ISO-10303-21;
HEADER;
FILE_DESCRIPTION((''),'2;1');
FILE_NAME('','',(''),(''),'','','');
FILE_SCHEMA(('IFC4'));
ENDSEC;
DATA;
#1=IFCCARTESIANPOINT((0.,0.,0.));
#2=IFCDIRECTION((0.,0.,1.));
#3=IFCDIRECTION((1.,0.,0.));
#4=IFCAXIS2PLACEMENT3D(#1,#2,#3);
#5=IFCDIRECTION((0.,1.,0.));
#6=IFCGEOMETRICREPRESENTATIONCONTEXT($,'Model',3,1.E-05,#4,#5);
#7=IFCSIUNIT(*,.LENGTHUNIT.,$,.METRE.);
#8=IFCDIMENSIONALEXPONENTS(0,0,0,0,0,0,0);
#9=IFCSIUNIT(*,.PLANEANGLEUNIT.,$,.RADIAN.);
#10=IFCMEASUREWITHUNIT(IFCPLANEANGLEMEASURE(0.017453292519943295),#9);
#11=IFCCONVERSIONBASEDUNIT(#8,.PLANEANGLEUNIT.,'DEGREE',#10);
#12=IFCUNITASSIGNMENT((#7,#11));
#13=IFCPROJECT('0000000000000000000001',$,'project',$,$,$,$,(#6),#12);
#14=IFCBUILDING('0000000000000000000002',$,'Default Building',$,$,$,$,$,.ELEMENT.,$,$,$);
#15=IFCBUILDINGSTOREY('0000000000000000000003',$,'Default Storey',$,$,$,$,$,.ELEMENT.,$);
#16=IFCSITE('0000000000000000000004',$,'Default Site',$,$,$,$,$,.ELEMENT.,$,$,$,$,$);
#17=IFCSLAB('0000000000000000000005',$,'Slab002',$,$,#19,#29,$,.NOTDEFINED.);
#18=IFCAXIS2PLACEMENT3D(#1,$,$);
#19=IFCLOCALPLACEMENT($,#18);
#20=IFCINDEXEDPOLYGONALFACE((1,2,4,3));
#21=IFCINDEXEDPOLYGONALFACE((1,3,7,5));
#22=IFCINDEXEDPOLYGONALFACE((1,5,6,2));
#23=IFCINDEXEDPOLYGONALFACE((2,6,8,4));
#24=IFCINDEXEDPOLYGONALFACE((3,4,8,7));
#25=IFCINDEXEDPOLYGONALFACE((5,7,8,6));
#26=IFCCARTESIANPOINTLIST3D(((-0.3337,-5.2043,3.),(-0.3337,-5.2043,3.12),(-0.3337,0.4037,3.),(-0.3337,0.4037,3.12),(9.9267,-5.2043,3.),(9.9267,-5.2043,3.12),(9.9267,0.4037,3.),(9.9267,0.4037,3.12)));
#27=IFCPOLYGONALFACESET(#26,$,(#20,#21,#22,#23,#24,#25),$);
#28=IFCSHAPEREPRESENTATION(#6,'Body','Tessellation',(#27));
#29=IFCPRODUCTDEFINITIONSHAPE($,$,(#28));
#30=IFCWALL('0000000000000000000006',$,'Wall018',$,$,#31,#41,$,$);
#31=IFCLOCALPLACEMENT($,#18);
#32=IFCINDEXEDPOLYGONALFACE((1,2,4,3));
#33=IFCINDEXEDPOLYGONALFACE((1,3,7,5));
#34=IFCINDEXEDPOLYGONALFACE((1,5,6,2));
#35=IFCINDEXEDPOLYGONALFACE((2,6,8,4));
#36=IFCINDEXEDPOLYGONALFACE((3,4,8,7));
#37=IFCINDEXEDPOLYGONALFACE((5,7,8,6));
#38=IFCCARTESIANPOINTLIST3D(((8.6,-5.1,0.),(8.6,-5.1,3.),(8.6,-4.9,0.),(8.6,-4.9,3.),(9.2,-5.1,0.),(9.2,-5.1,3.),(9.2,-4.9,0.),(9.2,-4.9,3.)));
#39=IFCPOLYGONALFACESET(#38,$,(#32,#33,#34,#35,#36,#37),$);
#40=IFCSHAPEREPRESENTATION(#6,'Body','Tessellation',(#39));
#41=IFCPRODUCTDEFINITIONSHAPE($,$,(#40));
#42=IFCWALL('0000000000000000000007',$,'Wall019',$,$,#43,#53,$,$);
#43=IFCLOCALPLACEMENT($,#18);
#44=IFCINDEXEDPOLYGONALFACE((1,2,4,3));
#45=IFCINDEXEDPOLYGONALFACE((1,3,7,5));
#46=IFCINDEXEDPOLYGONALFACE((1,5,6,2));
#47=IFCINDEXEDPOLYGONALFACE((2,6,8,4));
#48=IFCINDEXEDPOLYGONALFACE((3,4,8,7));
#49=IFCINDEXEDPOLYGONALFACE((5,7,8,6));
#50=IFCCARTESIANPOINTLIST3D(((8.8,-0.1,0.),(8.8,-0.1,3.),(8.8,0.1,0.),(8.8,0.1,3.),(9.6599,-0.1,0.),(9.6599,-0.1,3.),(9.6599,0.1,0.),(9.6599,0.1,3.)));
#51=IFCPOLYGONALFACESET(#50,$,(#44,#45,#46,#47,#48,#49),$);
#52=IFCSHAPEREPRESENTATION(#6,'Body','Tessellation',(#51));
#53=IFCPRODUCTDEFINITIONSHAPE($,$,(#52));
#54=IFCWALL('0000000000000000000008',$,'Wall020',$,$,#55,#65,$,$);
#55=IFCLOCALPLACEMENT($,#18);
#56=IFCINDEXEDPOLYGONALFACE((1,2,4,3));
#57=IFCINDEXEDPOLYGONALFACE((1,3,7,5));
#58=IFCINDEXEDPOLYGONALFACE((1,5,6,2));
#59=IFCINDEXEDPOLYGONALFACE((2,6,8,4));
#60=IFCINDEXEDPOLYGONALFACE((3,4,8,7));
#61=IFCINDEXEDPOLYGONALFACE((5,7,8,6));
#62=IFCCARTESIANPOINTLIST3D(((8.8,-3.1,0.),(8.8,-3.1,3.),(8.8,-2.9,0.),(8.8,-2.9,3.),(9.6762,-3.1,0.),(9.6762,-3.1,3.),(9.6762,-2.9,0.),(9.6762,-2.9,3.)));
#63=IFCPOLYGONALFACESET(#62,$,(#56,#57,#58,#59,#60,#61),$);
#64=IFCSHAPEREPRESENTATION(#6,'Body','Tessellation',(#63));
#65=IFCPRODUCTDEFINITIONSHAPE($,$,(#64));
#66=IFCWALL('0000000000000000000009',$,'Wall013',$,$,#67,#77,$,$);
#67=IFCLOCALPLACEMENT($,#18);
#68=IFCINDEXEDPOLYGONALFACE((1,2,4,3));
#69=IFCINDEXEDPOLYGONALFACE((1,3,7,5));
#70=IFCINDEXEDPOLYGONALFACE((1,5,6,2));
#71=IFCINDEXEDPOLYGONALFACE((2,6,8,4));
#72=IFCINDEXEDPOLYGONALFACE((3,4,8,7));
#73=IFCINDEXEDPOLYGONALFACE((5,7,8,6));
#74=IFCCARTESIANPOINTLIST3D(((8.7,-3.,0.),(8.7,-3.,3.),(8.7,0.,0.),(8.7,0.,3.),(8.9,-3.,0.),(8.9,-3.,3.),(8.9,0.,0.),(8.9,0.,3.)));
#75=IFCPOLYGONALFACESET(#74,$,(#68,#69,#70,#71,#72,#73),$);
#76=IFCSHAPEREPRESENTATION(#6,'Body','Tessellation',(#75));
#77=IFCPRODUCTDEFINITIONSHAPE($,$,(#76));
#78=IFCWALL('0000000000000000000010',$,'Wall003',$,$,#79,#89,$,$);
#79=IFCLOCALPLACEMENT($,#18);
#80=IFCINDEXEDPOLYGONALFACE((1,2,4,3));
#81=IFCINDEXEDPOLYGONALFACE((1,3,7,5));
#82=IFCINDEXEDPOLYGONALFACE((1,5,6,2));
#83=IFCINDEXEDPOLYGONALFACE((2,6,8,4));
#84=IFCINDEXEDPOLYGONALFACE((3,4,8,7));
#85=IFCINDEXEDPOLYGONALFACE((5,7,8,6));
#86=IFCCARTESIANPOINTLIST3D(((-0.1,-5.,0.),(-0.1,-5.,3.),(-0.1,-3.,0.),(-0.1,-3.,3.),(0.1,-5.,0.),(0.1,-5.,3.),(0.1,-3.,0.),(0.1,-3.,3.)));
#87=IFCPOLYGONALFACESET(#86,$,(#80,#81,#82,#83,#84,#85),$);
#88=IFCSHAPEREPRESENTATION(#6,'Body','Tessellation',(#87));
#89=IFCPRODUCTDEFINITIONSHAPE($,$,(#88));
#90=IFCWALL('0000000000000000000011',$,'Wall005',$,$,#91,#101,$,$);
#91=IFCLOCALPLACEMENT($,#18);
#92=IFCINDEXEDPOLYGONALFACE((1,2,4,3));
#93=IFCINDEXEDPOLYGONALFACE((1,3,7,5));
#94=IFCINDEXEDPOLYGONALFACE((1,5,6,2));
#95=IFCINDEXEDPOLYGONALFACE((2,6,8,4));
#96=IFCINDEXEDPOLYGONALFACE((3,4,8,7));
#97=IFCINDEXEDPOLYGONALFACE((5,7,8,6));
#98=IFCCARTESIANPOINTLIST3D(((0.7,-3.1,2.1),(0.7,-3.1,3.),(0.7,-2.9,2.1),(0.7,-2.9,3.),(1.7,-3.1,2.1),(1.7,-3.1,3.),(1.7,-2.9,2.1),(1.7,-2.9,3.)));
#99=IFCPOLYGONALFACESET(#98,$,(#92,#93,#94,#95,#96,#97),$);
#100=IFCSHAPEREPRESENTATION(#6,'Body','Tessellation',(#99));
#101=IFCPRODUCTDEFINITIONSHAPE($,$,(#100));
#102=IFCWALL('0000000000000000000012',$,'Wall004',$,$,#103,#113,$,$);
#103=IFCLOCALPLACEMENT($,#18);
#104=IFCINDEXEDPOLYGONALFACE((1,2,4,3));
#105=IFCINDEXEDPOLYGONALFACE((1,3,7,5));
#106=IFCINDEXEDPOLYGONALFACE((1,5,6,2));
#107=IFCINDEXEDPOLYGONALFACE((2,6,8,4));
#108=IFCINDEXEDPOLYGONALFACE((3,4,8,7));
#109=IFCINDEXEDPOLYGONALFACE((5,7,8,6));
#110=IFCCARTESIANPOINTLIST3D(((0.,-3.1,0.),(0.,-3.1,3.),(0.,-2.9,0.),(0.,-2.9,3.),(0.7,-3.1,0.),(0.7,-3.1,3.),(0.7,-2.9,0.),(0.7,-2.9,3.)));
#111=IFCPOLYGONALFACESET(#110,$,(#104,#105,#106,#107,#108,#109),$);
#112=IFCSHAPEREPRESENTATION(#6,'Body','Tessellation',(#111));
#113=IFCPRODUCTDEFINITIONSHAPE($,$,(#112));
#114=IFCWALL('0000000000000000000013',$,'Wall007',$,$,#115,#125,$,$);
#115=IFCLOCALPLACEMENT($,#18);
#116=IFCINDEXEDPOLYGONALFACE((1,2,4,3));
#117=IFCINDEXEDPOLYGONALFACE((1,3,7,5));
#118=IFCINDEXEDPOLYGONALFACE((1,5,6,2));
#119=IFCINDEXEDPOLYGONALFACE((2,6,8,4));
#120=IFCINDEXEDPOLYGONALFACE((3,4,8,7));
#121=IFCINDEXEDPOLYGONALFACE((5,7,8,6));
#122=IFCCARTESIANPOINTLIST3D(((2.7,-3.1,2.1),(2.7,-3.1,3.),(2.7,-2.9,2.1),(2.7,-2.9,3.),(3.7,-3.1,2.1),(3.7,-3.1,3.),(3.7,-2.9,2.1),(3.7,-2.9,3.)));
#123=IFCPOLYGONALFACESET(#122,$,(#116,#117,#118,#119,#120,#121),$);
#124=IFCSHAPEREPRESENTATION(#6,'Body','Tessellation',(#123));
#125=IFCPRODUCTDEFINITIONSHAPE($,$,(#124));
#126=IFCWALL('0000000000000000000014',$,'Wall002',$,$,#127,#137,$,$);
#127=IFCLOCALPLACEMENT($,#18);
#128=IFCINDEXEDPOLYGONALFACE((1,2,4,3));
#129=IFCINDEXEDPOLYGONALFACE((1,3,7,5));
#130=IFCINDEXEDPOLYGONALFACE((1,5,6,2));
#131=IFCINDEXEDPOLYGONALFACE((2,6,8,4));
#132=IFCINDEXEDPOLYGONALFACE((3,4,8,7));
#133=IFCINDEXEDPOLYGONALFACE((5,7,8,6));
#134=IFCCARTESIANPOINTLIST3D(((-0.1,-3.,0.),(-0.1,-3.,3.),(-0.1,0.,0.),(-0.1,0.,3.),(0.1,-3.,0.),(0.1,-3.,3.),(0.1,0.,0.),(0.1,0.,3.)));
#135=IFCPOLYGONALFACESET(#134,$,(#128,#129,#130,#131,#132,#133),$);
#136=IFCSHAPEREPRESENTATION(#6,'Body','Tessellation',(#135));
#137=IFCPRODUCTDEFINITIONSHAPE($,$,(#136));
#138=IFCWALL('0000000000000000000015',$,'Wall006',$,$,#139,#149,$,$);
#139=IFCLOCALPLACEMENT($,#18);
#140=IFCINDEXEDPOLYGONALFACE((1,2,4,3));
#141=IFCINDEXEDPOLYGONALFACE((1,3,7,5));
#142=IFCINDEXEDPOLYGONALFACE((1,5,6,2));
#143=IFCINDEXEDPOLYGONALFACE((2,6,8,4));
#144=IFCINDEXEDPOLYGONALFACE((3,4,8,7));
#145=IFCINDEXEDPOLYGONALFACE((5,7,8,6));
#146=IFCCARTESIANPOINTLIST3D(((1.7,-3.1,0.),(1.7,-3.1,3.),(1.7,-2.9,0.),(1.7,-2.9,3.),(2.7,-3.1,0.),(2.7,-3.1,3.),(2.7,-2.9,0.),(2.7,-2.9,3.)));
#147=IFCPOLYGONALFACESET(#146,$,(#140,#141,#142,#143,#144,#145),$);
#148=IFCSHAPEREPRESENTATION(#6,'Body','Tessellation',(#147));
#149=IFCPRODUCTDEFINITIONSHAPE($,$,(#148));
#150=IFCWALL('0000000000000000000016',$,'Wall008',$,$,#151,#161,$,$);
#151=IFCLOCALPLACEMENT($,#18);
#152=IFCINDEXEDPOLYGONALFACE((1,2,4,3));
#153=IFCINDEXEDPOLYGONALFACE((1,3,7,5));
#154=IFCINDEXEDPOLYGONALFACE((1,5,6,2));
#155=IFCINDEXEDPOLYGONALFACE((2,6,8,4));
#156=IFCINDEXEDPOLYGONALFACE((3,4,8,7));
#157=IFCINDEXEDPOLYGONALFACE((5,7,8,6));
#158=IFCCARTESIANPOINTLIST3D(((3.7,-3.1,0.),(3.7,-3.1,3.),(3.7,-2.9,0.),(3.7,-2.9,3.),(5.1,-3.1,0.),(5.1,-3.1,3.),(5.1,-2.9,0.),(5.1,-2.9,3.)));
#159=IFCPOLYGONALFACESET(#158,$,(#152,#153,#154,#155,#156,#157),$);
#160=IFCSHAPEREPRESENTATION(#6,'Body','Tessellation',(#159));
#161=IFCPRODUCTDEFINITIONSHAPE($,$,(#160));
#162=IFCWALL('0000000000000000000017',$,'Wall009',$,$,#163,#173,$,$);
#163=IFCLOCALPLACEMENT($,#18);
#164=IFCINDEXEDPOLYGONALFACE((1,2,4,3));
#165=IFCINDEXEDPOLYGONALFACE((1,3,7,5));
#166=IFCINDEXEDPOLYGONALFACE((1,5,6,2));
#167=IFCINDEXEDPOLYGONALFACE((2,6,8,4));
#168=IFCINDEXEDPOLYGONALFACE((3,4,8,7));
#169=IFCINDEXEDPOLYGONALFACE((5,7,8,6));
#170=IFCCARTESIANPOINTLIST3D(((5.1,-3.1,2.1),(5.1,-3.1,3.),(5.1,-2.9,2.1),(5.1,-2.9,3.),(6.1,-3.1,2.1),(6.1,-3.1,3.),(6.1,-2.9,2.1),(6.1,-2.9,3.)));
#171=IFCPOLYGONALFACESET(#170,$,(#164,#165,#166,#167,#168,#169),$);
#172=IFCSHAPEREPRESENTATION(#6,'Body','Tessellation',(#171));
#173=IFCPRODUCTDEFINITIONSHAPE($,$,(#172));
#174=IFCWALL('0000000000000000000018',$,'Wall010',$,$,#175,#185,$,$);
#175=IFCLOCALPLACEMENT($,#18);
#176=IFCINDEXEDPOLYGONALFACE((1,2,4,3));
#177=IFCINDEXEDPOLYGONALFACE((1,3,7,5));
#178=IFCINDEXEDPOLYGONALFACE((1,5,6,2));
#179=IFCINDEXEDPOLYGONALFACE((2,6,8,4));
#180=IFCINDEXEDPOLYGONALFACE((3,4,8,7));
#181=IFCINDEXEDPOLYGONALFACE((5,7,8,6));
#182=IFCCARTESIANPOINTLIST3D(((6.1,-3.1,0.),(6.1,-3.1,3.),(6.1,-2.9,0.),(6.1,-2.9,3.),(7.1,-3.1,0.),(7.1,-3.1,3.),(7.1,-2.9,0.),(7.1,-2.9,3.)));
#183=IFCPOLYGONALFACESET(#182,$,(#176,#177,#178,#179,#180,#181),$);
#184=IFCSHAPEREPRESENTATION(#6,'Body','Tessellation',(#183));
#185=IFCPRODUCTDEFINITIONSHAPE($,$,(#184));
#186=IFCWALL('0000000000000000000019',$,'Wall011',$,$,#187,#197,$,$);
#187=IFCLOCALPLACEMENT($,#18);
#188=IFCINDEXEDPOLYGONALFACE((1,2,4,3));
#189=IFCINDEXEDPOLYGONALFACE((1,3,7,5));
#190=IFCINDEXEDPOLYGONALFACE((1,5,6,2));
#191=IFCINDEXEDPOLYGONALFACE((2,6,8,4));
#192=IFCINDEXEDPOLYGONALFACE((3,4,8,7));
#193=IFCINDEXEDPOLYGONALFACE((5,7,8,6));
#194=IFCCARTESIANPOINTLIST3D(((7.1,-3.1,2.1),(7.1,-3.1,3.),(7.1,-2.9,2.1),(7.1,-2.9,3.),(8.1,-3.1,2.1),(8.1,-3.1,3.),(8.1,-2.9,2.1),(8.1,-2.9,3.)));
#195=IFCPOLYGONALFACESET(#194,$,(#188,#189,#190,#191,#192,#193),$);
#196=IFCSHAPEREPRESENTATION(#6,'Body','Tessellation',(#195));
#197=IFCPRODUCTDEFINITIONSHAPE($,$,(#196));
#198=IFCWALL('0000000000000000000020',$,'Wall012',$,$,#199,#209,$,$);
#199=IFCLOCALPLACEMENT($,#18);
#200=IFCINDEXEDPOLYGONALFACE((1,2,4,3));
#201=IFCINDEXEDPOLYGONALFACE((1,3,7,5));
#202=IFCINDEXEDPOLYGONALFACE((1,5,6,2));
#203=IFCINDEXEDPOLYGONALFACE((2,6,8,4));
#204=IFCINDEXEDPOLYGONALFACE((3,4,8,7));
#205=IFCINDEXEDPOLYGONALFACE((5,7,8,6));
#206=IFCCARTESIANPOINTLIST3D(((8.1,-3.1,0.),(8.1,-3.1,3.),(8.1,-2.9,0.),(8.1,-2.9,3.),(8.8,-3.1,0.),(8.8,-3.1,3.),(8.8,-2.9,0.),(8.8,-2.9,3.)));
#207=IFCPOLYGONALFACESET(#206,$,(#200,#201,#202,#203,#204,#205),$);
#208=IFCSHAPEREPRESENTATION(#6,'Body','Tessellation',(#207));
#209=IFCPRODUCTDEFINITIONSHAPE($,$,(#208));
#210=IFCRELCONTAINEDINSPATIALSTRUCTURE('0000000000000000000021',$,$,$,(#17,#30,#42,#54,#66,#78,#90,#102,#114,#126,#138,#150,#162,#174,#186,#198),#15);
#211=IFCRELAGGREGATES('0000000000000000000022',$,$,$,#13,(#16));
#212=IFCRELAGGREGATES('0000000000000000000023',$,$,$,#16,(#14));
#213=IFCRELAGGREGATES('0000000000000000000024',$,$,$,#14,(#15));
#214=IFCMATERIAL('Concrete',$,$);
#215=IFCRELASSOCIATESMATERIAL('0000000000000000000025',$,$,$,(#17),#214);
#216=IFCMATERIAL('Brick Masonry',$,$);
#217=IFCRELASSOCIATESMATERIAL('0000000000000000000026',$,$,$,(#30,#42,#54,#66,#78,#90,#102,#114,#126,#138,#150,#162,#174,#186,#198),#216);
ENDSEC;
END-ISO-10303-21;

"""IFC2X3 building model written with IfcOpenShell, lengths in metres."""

from ifc_helpers import new_model, entity, si_unit, converted_unit, direction, frame, frame_2d, origin_with_axes, place, context, project, spatial, rectangle, extrude, material, element, save


model = new_model("IFC2X3")

# Units and contexts
model_context = context("Model", 3, precision=1e-05, world=origin_with_axes(), true_north=direction((0.0, 1.0, 0.0)))
ifc_project = project(units=[si_unit("LENGTHUNIT", "METRE"), converted_unit("PLANEANGLEUNIT", "DEGREE", entity("IfcPlaneAngleMeasure", 0.017453292519943295), si_unit("PLANEANGLEUNIT", "RADIAN"), dimensions=[0, 0, 0, 0, 0, 0, 0])], contexts=[model_context])

# Site, building, storey
site = spatial("IfcSite", under=ifc_project, Name="Default Site", CompositionType="ELEMENT")
building = spatial("IfcBuilding", under=site, Name="Default Building", CompositionType="ELEMENT")
storey = spatial("IfcBuildingStorey", under=building, Name="Default Storey", CompositionType="ELEMENT")

# Slab
ifc_material_1 = material(Name="Concrete")
placement = place(None, origin_with_axes())
element("IfcSlab", 1, at=placement, inside=storey, material=ifc_material_1, Name="Slab002", PredefinedType="NOTDEFINED", context=model_context, shape_type="SweptSolid", body=[
    extrude(rectangle(XDim=10.2604, YDim=5.608, at=frame_2d((0.0, 0.0), x_axis=(1.0, 0.0, 0.0))), frame((4.7965, -2.4003, 3.0), z_axis=(0.0, 0.0, 1.0), x_axis=(1.0, 0.0, 0.0)), (0.0, 0.0, 1.0), 0.12),
])

# Walls
ifc_material_2 = material(Name="Brick Masonry")
element("IfcWall", 2, at=placement, inside=storey, material=ifc_material_2, Name="Wall018", context=model_context, shape_type="SweptSolid", body=[
    extrude(rectangle(XDim=0.6, YDim=0.2, at=frame_2d((0.0, 0.0), x_axis=(1.0, 0.0, 0.0))), frame((8.9, -5.0, 0.0), z_axis=(0.0, 0.0, 1.0), x_axis=(1.0, 0.0, 0.0)), (0.0, 0.0, 1.0), 3.0),
])
element("IfcWall", 3, at=placement, inside=storey, material=ifc_material_2, Name="Wall019", context=model_context, shape_type="SweptSolid", body=[
    extrude(rectangle(XDim=0.8599, YDim=0.2, at=frame_2d((0.0, 0.0), x_axis=(1.0, 0.0, 0.0))), frame((9.2299, 0.0, 0.0), z_axis=(0.0, 0.0, 1.0), x_axis=(1.0, 0.0, 0.0)), (0.0, 0.0, 1.0), 3.0),
])
element("IfcWall", 4, at=placement, inside=storey, material=ifc_material_2, Name="Wall020", context=model_context, shape_type="SweptSolid", body=[
    extrude(rectangle(XDim=0.8762, YDim=0.2, at=frame_2d((0.0, 0.0), x_axis=(1.0, 0.0, 0.0))), frame((9.2381, -3.0, 0.0), z_axis=(0.0, 0.0, 1.0), x_axis=(1.0, 0.0, 0.0)), (0.0, 0.0, 1.0), 3.0),
])
element("IfcWall", 5, at=placement, inside=storey, material=ifc_material_2, Name="Wall013", context=model_context, shape_type="SweptSolid", body=[
    extrude(rectangle(XDim=3.0, YDim=0.2, at=frame_2d((0.0, 0.0), x_axis=(0.0, -1.0, 0.0))), frame((8.8, -1.5, 0.0), z_axis=(0.0, 0.0, 1.0), x_axis=(1.0, 0.0, 0.0)), (0.0, 0.0, 1.0), 3.0),
])
element("IfcWall", 6, at=placement, inside=storey, material=ifc_material_2, Name="Wall003", context=model_context, shape_type="SweptSolid", body=[
    extrude(rectangle(XDim=2.0, YDim=0.2, at=frame_2d((0.0, 0.0), x_axis=(0.0, -1.0, 0.0))), frame((0.0, -4.0, 0.0), z_axis=(0.0, 0.0, 1.0), x_axis=(1.0, 0.0, 0.0)), (0.0, 0.0, 1.0), 3.0),
])
element("IfcWall", 7, at=placement, inside=storey, material=ifc_material_2, Name="Wall005", context=model_context, shape_type="SweptSolid", body=[
    extrude(rectangle(XDim=1.0, YDim=0.2, at=frame_2d((0.0, 0.0), x_axis=(1.0, 0.0, 0.0))), frame((1.2, -3.0, 2.1), z_axis=(0.0, 0.0, 1.0), x_axis=(1.0, 0.0, 0.0)), (0.0, 0.0, 1.0), 0.9),
])
element("IfcWall", 8, at=placement, inside=storey, material=ifc_material_2, Name="Wall004", context=model_context, shape_type="SweptSolid", body=[
    extrude(rectangle(XDim=0.7, YDim=0.2, at=frame_2d((0.0, 0.0), x_axis=(1.0, 0.0, 0.0))), frame((0.35, -3.0, 0.0), z_axis=(0.0, 0.0, 1.0), x_axis=(1.0, 0.0, 0.0)), (0.0, 0.0, 1.0), 3.0),
])
element("IfcWall", 9, at=placement, inside=storey, material=ifc_material_2, Name="Wall007", context=model_context, shape_type="SweptSolid", body=[
    extrude(rectangle(XDim=1.0, YDim=0.2, at=frame_2d((0.0, 0.0), x_axis=(1.0, 0.0, 0.0))), frame((3.2, -3.0, 2.1), z_axis=(0.0, 0.0, 1.0), x_axis=(1.0, 0.0, 0.0)), (0.0, 0.0, 1.0), 0.9),
])
element("IfcWall", 10, at=placement, inside=storey, material=ifc_material_2, Name="Wall002", context=model_context, shape_type="SweptSolid", body=[
    extrude(rectangle(XDim=3.0, YDim=0.2, at=frame_2d((0.0, 0.0), x_axis=(0.0, -1.0, 0.0))), frame((0.0, -1.5, 0.0), z_axis=(0.0, 0.0, 1.0), x_axis=(1.0, 0.0, 0.0)), (0.0, 0.0, 1.0), 3.0),
])
element("IfcWall", 11, at=placement, inside=storey, material=ifc_material_2, Name="Wall006", context=model_context, shape_type="SweptSolid", body=[
    extrude(rectangle(XDim=1.0, YDim=0.2, at=frame_2d((0.0, 0.0), x_axis=(1.0, 0.0, 0.0))), frame((2.2, -3.0, 0.0), z_axis=(0.0, 0.0, 1.0), x_axis=(1.0, 0.0, 0.0)), (0.0, 0.0, 1.0), 3.0),
])
element("IfcWall", 12, at=placement, inside=storey, material=ifc_material_2, Name="Wall008", context=model_context, shape_type="SweptSolid", body=[
    extrude(rectangle(XDim=1.4, YDim=0.2, at=frame_2d((0.0, 0.0), x_axis=(1.0, 0.0, 0.0))), frame((4.4, -3.0, 0.0), z_axis=(0.0, 0.0, 1.0), x_axis=(1.0, 0.0, 0.0)), (0.0, 0.0, 1.0), 3.0),
])
element("IfcWall", 13, at=placement, inside=storey, material=ifc_material_2, Name="Wall009", context=model_context, shape_type="SweptSolid", body=[
    extrude(rectangle(XDim=1.0, YDim=0.2, at=frame_2d((0.0, 0.0), x_axis=(1.0, 0.0, 0.0))), frame((5.6, -3.0, 2.1), z_axis=(0.0, 0.0, 1.0), x_axis=(1.0, 0.0, 0.0)), (0.0, 0.0, 1.0), 0.9),
])
element("IfcWall", 14, at=placement, inside=storey, material=ifc_material_2, Name="Wall010", context=model_context, shape_type="SweptSolid", body=[
    extrude(rectangle(XDim=1.0, YDim=0.2, at=frame_2d((0.0, 0.0), x_axis=(1.0, 0.0, 0.0))), frame((6.6, -3.0, 0.0), z_axis=(0.0, 0.0, 1.0), x_axis=(1.0, 0.0, 0.0)), (0.0, 0.0, 1.0), 3.0),
])
element("IfcWall", 15, at=placement, inside=storey, material=ifc_material_2, Name="Wall011", context=model_context, shape_type="SweptSolid", body=[
    extrude(rectangle(XDim=1.0, YDim=0.2, at=frame_2d((0.0, 0.0), x_axis=(1.0, 0.0, 0.0))), frame((7.6, -3.0, 2.1), z_axis=(0.0, 0.0, 1.0), x_axis=(1.0, 0.0, 0.0)), (0.0, 0.0, 1.0), 0.9),
])
element("IfcWall", 16, at=placement, inside=storey, material=ifc_material_2, Name="Wall012", context=model_context, shape_type="SweptSolid", body=[
    extrude(rectangle(XDim=0.7, YDim=0.2, at=frame_2d((0.0, 0.0), x_axis=(1.0, 0.0, 0.0))), frame((8.45, -3.0, 0.0), z_axis=(0.0, 0.0, 1.0), x_axis=(1.0, 0.0, 0.0)), (0.0, 0.0, 1.0), 3.0),
])

save(model, "model.ifc")
